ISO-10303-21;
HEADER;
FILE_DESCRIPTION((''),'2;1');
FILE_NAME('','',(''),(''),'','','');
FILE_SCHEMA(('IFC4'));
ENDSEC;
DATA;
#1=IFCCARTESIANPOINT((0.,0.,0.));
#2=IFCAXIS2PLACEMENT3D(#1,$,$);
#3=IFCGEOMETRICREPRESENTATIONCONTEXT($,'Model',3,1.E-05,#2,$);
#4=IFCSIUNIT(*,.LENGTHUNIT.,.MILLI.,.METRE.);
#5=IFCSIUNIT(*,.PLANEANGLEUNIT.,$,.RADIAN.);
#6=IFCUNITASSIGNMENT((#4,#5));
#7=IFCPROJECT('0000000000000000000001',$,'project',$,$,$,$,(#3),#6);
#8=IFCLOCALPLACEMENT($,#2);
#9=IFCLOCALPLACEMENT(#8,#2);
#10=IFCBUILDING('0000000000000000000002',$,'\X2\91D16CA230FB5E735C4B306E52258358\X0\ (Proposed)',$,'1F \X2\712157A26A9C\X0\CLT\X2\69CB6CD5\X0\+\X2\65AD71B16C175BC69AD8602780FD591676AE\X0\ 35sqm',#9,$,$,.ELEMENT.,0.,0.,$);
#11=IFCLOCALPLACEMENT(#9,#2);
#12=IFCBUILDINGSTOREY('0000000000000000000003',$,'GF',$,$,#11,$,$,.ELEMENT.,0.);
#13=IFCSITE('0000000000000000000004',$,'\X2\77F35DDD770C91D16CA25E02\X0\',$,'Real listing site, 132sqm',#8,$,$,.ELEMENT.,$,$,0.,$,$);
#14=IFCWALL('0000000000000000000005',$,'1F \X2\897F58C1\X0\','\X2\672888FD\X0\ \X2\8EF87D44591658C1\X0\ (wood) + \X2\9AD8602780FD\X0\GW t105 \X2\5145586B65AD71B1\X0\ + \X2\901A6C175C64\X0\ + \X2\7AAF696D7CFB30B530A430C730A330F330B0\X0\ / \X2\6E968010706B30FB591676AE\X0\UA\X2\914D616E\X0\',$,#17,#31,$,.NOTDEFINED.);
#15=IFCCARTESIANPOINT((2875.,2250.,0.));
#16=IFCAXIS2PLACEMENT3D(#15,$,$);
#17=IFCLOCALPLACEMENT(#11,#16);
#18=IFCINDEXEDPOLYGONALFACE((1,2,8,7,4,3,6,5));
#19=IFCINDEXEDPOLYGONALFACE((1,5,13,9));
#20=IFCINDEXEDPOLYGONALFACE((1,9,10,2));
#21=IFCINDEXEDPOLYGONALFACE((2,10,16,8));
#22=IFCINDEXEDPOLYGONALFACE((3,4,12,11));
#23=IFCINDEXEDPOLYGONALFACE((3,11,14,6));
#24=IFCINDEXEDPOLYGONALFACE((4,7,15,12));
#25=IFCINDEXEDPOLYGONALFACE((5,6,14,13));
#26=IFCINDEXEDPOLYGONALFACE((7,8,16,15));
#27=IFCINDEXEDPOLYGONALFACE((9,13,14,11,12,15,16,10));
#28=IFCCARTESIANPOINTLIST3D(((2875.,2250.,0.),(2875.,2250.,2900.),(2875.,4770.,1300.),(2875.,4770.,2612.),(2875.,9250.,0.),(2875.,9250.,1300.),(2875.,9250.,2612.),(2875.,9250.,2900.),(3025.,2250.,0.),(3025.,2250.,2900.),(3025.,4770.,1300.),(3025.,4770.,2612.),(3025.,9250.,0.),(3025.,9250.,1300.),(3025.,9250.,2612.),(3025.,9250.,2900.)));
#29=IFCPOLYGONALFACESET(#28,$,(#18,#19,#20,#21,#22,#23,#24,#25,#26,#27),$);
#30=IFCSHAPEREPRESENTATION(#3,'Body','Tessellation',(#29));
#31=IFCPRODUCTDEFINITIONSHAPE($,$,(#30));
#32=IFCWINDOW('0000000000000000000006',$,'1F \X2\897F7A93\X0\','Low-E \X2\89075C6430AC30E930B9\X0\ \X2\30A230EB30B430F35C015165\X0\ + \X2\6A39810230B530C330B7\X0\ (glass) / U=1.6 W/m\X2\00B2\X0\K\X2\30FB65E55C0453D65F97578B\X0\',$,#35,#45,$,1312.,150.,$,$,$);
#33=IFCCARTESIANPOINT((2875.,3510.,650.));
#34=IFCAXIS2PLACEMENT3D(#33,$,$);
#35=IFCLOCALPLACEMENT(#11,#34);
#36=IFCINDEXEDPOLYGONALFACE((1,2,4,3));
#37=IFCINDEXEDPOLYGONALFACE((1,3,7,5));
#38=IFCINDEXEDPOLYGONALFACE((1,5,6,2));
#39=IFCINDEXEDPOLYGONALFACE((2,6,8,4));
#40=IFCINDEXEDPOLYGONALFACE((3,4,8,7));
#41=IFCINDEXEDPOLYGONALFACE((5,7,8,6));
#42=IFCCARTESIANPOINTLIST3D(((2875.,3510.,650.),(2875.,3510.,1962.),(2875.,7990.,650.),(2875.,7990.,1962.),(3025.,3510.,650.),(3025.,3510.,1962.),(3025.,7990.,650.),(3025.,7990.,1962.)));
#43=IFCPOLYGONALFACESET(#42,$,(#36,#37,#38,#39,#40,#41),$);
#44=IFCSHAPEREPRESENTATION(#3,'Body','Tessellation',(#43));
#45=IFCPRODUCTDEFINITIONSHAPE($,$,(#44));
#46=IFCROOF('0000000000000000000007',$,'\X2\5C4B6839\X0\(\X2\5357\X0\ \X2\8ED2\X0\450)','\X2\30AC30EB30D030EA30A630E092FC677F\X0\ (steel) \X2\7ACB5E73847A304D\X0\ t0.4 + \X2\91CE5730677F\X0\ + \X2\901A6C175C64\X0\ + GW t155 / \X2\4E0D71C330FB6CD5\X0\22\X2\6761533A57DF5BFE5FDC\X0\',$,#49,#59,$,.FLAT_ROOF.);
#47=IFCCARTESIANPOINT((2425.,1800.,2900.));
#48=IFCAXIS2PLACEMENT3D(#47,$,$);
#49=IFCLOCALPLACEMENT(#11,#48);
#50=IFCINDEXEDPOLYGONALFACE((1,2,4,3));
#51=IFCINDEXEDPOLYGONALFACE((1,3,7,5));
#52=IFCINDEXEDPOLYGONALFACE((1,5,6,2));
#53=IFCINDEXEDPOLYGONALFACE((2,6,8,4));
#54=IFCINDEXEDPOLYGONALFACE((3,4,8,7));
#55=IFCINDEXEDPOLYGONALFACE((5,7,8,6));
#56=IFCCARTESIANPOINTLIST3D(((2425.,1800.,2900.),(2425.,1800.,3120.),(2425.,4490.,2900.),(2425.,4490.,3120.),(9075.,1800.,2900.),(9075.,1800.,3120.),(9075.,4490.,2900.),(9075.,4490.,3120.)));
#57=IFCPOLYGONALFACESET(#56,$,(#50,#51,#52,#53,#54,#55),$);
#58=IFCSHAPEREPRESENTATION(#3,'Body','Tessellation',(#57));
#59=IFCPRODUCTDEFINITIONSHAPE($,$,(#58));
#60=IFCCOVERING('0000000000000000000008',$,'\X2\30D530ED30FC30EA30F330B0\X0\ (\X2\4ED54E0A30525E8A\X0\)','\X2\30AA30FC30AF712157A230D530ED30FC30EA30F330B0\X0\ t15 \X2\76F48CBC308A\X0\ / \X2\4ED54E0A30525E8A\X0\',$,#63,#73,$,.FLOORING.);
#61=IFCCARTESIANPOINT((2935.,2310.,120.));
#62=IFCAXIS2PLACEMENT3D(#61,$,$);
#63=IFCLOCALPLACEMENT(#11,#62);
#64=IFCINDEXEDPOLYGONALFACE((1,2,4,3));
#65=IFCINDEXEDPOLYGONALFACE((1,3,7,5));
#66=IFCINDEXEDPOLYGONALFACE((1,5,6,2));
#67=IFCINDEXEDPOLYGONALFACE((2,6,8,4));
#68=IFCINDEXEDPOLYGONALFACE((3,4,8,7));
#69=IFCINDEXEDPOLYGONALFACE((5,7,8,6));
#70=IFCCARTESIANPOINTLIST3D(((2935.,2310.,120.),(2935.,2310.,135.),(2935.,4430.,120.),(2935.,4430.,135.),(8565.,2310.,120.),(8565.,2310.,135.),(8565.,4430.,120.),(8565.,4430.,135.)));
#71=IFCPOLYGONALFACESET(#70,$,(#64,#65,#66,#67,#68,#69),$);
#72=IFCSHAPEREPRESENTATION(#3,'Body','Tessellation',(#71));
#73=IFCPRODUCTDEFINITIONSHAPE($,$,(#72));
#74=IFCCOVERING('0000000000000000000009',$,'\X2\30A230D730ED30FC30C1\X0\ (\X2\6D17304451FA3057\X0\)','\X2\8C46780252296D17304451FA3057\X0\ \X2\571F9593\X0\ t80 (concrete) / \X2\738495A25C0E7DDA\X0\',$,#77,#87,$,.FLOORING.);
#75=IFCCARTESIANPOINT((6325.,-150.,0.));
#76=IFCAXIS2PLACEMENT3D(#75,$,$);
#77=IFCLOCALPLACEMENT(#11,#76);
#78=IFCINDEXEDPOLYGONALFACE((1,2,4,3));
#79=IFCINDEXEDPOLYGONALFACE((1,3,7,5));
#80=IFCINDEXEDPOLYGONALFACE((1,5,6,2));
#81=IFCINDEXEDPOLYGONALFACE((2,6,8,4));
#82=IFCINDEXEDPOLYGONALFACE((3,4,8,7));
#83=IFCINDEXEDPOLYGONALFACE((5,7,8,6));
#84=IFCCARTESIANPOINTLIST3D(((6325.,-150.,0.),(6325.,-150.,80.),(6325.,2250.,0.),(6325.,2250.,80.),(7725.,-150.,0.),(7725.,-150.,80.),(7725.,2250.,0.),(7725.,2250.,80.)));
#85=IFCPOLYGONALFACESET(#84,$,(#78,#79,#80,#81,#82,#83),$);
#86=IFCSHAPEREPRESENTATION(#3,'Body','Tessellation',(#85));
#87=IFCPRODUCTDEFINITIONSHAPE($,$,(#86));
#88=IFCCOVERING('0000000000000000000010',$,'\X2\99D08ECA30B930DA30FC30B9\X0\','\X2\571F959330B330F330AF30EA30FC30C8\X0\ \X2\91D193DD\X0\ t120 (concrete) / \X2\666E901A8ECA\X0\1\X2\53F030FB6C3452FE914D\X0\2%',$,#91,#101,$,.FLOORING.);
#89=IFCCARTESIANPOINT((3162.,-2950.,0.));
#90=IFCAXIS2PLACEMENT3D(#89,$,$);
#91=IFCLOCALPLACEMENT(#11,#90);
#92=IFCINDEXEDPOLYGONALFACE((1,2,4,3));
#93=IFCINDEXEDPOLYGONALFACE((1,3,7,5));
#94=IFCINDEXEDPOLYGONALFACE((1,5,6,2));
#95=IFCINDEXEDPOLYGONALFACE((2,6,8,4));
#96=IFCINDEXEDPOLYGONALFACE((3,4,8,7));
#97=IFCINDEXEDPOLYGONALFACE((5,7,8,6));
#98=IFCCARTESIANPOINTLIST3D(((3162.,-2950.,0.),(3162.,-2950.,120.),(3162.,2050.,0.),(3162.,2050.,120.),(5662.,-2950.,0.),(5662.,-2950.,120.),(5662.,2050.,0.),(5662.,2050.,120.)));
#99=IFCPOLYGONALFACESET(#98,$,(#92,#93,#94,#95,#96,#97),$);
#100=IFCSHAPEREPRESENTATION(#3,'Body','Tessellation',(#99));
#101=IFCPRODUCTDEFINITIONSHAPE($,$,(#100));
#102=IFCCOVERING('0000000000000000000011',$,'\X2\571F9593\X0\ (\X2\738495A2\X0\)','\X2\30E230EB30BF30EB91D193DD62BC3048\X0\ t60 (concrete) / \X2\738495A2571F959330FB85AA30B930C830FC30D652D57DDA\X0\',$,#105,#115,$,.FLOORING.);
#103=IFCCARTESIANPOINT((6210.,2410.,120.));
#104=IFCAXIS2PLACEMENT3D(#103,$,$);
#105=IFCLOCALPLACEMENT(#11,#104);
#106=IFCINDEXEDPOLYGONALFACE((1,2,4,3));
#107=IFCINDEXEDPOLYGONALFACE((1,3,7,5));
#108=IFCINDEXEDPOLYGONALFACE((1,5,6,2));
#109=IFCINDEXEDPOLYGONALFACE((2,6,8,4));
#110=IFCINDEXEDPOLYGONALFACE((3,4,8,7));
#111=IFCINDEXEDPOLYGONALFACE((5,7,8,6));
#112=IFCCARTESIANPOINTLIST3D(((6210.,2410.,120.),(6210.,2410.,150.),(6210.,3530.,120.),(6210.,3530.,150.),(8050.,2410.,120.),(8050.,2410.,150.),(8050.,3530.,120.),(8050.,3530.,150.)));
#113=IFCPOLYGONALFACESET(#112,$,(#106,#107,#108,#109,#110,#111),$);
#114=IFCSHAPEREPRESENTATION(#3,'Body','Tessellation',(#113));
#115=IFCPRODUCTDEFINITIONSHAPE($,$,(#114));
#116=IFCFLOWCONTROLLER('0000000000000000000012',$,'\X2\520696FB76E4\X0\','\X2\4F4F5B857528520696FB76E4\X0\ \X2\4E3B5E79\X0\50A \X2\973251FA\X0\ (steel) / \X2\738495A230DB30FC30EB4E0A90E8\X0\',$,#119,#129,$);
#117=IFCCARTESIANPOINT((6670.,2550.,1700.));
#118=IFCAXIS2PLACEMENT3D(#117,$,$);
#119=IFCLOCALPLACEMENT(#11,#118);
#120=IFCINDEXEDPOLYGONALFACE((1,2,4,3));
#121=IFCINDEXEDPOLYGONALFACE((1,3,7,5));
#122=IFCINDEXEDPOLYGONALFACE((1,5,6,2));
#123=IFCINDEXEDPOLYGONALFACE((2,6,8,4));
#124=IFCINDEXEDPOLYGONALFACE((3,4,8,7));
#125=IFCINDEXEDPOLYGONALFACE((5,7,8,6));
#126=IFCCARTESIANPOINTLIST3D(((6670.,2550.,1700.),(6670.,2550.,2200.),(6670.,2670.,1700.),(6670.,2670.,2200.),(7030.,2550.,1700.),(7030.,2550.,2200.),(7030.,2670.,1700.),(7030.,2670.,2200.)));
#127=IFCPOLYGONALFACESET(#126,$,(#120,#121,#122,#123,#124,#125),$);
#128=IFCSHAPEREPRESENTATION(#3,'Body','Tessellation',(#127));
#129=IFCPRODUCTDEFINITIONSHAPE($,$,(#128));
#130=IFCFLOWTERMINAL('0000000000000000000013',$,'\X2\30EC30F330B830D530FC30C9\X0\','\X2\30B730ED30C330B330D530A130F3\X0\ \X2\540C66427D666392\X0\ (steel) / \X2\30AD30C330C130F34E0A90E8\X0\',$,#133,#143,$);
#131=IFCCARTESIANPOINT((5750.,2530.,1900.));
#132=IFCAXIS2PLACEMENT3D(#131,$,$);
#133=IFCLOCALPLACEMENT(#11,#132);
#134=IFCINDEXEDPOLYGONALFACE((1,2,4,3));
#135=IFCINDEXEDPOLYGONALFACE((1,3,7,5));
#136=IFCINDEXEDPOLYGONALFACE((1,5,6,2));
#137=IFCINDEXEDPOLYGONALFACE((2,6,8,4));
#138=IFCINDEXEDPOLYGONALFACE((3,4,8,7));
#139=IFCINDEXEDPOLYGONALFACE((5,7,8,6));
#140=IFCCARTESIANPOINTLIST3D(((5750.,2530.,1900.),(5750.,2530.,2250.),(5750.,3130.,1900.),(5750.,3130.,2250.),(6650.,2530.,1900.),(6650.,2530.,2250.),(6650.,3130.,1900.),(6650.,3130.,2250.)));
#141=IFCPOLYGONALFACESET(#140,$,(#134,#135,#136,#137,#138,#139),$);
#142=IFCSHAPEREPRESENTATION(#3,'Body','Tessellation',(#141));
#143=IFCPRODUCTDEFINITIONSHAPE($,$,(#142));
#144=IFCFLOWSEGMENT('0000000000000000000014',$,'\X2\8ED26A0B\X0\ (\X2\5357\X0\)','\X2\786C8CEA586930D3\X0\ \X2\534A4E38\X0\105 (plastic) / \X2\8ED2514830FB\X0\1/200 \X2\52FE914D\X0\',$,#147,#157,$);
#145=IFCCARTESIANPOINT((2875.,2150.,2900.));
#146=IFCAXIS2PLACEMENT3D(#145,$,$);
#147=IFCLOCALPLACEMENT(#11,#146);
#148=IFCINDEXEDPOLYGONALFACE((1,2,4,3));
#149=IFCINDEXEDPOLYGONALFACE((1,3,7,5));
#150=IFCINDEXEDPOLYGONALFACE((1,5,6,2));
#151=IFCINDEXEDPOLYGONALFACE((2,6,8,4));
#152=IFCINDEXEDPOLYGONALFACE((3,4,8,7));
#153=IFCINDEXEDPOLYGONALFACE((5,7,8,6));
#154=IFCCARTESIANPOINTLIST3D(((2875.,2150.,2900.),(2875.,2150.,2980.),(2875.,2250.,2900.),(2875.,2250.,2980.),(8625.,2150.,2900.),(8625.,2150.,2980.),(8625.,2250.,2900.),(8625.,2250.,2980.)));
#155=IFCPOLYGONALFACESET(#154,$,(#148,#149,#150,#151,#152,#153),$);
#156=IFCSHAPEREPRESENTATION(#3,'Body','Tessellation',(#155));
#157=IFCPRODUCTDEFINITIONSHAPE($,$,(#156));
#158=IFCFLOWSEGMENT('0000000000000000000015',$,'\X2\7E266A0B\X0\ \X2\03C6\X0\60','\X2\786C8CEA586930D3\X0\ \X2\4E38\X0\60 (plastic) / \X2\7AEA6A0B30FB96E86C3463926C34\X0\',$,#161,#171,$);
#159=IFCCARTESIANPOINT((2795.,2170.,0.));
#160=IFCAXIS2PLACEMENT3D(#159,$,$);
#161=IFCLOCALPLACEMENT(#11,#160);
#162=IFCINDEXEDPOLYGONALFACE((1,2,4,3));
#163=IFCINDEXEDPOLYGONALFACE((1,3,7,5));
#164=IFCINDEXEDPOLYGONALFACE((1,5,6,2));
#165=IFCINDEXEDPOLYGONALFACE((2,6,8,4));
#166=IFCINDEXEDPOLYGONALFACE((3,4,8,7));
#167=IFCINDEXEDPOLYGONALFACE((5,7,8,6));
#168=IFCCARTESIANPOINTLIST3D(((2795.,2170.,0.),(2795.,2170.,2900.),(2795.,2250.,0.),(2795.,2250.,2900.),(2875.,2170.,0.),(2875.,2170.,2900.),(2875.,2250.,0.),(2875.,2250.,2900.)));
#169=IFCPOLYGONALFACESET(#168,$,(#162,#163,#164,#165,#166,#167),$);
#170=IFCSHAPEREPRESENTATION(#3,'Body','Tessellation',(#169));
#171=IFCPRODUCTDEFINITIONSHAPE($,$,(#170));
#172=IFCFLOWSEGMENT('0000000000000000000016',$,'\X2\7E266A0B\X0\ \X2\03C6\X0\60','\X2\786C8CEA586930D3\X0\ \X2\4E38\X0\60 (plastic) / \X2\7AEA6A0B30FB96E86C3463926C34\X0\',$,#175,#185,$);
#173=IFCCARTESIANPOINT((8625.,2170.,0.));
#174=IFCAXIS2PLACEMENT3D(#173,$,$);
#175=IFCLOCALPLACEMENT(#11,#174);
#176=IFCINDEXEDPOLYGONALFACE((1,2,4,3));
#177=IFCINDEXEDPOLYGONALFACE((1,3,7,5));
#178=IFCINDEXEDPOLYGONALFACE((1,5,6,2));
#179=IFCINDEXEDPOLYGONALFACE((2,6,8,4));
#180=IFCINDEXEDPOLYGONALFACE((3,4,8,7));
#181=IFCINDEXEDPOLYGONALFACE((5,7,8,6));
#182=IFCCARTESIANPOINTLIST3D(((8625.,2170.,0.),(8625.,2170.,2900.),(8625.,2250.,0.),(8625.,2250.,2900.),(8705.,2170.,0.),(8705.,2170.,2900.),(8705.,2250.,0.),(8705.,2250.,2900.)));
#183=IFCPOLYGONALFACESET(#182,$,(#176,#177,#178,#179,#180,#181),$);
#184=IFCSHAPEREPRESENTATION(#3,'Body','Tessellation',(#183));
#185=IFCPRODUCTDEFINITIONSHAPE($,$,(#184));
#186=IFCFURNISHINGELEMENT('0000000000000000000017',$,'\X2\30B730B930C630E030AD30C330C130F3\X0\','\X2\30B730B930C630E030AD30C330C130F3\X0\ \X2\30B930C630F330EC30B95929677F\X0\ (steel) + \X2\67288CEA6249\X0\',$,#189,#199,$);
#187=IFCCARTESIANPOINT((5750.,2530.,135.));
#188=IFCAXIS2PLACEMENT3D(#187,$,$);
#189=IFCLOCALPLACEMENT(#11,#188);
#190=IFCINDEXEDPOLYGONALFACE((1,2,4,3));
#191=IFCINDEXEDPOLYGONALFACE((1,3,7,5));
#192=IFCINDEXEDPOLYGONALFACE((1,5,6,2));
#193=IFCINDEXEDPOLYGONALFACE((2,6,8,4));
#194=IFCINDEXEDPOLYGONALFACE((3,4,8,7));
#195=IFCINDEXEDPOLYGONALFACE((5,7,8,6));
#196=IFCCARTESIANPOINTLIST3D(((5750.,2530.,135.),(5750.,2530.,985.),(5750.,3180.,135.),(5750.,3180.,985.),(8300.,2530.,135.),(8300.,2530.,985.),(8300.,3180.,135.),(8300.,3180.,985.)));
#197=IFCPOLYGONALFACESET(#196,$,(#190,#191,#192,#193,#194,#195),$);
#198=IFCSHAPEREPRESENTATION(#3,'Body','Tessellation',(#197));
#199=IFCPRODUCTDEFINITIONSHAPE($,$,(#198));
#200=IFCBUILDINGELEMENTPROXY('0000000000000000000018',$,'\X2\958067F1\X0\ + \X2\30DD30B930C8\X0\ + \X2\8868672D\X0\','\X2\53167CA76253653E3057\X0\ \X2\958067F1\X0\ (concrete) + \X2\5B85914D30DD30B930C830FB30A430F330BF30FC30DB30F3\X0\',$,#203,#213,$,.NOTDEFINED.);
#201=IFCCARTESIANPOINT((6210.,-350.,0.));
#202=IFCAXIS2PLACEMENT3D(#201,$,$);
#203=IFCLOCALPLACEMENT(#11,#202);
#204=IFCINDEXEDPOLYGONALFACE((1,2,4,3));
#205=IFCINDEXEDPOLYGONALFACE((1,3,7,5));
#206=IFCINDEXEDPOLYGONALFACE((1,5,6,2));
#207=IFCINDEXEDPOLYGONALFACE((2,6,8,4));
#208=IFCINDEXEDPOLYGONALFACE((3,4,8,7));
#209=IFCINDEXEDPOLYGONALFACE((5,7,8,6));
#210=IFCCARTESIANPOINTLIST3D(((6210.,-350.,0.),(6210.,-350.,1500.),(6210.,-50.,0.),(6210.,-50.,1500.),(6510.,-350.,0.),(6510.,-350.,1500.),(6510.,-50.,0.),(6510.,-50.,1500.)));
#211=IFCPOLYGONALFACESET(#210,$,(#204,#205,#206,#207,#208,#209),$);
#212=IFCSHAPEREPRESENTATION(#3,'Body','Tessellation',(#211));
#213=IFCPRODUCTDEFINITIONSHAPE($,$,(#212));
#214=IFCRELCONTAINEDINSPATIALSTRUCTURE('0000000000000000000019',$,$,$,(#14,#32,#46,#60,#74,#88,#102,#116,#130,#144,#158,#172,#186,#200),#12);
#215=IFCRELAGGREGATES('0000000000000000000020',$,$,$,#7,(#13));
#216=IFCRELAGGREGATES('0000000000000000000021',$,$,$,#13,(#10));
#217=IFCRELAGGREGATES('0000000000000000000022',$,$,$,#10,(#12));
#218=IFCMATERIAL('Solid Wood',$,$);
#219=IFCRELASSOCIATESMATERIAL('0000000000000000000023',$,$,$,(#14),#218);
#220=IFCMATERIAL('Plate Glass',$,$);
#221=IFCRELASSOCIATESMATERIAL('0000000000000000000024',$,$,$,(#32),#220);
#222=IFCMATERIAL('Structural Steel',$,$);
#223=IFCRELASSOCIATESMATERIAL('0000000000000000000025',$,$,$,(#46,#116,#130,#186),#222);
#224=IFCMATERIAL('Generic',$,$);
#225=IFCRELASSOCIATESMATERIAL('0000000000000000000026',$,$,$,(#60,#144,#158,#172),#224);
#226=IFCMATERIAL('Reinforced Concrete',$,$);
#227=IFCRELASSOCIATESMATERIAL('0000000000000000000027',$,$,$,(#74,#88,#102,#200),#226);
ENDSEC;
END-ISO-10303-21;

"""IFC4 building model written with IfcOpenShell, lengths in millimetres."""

from ifc_helpers import new_model, si_unit, frame, frame_2d, origin, place, context, project, spatial, rectangle, extrude, material, element, fill, save


model = new_model("IFC4")

# Units and contexts
model_context = context("Model", 3, precision=1e-05, world=origin())
ifc_project = project(units=[si_unit("LENGTHUNIT", "METRE", prefix="MILLI"), si_unit("PLANEANGLEUNIT", "RADIAN")], contexts=[model_context])

# Site, building, storey
site_placement = place(None, origin())
site = spatial("IfcSite", under=ifc_project, at=site_placement, Name="石川県金沢市", ObjectType="Real listing site, 132sqm", CompositionType="ELEMENT", RefElevation=0.0)
building_placement = place(site_placement, origin())
building = spatial("IfcBuilding", under=site, at=building_placement, Name="金沢・平屋の別荘 (Proposed)", ObjectType="1F 無垢檜CLT構法+断熱気密高性能外皮 35sqm", CompositionType="ELEMENT", ElevationOfRefHeight=0.0, ElevationOfTerrain=0.0)
storey_placement = place(building_placement, origin())
storey = spatial("IfcBuildingStorey", under=building, at=storey_placement, Name="GF", CompositionType="ELEMENT", Elevation=0.0)

# Shared definitions
ifc_material_1 = material(Name="Solid Wood")

# Shared definitions
ifc_material_2 = material(Name="Reinforced Concrete")

# Shared definitions
ifc_material_3 = material(Name="Plate Glass")

# Wall, opening, window
wall_1_placement = place(storey_placement, frame((2875.0, 2250.0, 0.0)))
wall_1 = element("IfcWall", 1, at=wall_1_placement, inside=storey, material=ifc_material_1, Name="1F 西壁", Description="木製 軸組外壁 (wood) + 高性能GW t105 充填断熱 + 通気層 + 窯業系サイディング / 準耐火・外皮UA配慮", PredefinedType="NOTDEFINED", context=model_context, shape_type="SweptSolid", body=[
    extrude(rectangle(XDim=150.0, YDim=7000.0, at=frame_2d((75.0, 3500.0))), frame((2875.0, 2250.0, 0.0)), (0.0, 0.0, 1.0), 2900.0),
])
opening_1_placement = place(storey_placement, frame((2875.0, 3510.0, 650.0)))
opening_1 = element("IfcOpeningElement", 2, at=opening_1_placement, cuts=wall_1, PredefinedType="NOTDEFINED", context=model_context, shape_type="SweptSolid", body=[
    extrude(rectangle(XDim=150.0, YDim=4480.0, at=frame_2d((75.0, 2240.0))), frame((2875.0, 3510.0, 650.0)), (0.0, 0.0, 1.0), 1312.0),
])
window_1_placement = place(storey_placement, frame((2875.0, 3510.0, 650.0)))
window_1 = element("IfcWindow", 3, at=window_1_placement, inside=storey, material=ifc_material_3, Name="1F 西窓", Description="Low-E 複層ガラス アルゴン封入 + 樹脂サッシ (glass) / U=1.6 W/m²K・日射取得型", OverallHeight=1312.0, OverallWidth=150.0, context=model_context, shape_type="SweptSolid", body=[
    extrude(rectangle(XDim=150.0, YDim=4480.0, at=frame_2d((75.0, 2240.0))), frame((2875.0, 3510.0, 650.0)), (0.0, 0.0, 1.0), 1312.0),
])
fill(opening_1, window_1)

# Roof
ifc_material_4 = material(Name="Structural Steel")
roof_placement = place(storey_placement, frame((2425.0, 1800.0, 2900.0)))
element("IfcRoof", 4, at=roof_placement, inside=storey, material=ifc_material_4, Name="屋根(南 軒450)", Description="ガルバリウム鋼板 (steel) 立平葺き t0.4 + 野地板 + 通気層 + GW t155 / 不燃・法22条区域対応", PredefinedType="FLAT_ROOF", context=model_context, shape_type="SweptSolid", body=[
    extrude(rectangle(XDim=6650.0, YDim=2690.0, at=frame_2d((3325.0, 1345.0))), frame((2425.0, 1800.0, 2900.0)), (0.0, 0.0, 1.0), 220.0),
])

# Coverings
ifc_material_5 = material(Name="Generic")
covering_1_placement = place(storey_placement, frame((2935.0, 2310.0, 120.0)))
element("IfcCovering", 5, at=covering_1_placement, inside=storey, material=ifc_material_5, Name="フローリング (仕上げ床)", Description="オーク無垢フローリング t15 直貼り / 仕上げ床", PredefinedType="FLOORING", context=model_context, shape_type="SweptSolid", body=[
    extrude(rectangle(XDim=5630.0, YDim=2120.0, at=frame_2d((2815.0, 1060.0))), frame((2935.0, 2310.0, 120.0)), (0.0, 0.0, 1.0), 15.0),
])
covering_2_placement = place(storey_placement, frame((6325.0, -150.0, 0.0)))
element("IfcCovering", 6, at=covering_2_placement, inside=storey, material=ifc_material_2, Name="アプローチ (洗い出し)", Description="豆砂利洗い出し 土間 t80 (concrete) / 玄関導線", PredefinedType="FLOORING", context=model_context, shape_type="SweptSolid", body=[
    extrude(rectangle(XDim=1400.0, YDim=2400.0, at=frame_2d((700.0, 1200.0))), frame((6325.0, -150.0, 0.0)), (0.0, 0.0, 1.0), 80.0),
])
covering_3_placement = place(storey_placement, frame((3162.0, -2950.0, 0.0)))
element("IfcCovering", 7, at=covering_3_placement, inside=storey, material=ifc_material_2, Name="駐車スペース", Description="土間コンクリート 金鏝 t120 (concrete) / 普通車1台・水勾配2%", PredefinedType="FLOORING", context=model_context, shape_type="SweptSolid", body=[
    extrude(rectangle(XDim=2500.0, YDim=5000.0, at=frame_2d((1250.0, 2500.0))), frame((3162.0, -2950.0, 0.0)), (0.0, 0.0, 1.0), 120.0),
])
covering_4_placement = place(storey_placement, frame((6210.0, 2410.0, 120.0)))
element("IfcCovering", 8, at=covering_4_placement, inside=storey, material=ifc_material_2, Name="土間 (玄関)", Description="モルタル金鏝押え t60 (concrete) / 玄関土間・薪ストーブ動線", PredefinedType="FLOORING", context=model_context, shape_type="SweptSolid", body=[
    extrude(rectangle(XDim=1840.0, YDim=1120.0, at=frame_2d((920.0, 560.0))), frame((6210.0, 2410.0, 120.0)), (0.0, 0.0, 1.0), 30.0),
])

# Flow controller
flow_controller_placement = place(storey_placement, frame((6670.0, 2550.0, 1700.0)))
element("IfcFlowController", 9, at=flow_controller_placement, inside=storey, material=ifc_material_4, Name="分電盤", Description="住宅用分電盤 主幹50A 露出 (steel) / 玄関ホール上部", context=model_context, shape_type="SweptSolid", body=[
    extrude(rectangle(XDim=360.0, YDim=120.0, at=frame_2d((180.0, 60.0))), frame((6670.0, 2550.0, 1700.0)), (0.0, 0.0, 1.0), 500.0),
])

# Flow terminal
flow_terminal_placement = place(storey_placement, frame((5750.0, 2530.0, 1900.0)))
element("IfcFlowTerminal", 10, at=flow_terminal_placement, inside=storey, material=ifc_material_4, Name="レンジフード", Description="シロッコファン 同時給排 (steel) / キッチン上部", context=model_context, shape_type="SweptSolid", body=[
    extrude(rectangle(XDim=900.0, YDim=600.0, at=frame_2d((450.0, 300.0))), frame((5750.0, 2530.0, 1900.0)), (0.0, 0.0, 1.0), 350.0),
])

# Flow segments
flow_segment_1_placement = place(storey_placement, frame((2875.0, 2150.0, 2900.0)))
element("IfcFlowSegment", 11, at=flow_segment_1_placement, inside=storey, material=ifc_material_5, Name="軒樋 (南)", Description="硬質塩ビ 半丸105 (plastic) / 軒先・1/200 勾配", context=model_context, shape_type="SweptSolid", body=[
    extrude(rectangle(XDim=5750.0, YDim=100.0, at=frame_2d((2875.0, 50.0))), frame((2875.0, 2150.0, 2900.0)), (0.0, 0.0, 1.0), 80.0),
])
flow_segment_2_placement = place(storey_placement, frame((2795.0, 2170.0, 0.0)))
element("IfcFlowSegment", 12, at=flow_segment_2_placement, inside=storey, material=ifc_material_5, Name="縦樋 φ60", Description="硬質塩ビ 丸60 (plastic) / 竪樋・雨水排水", context=model_context, shape_type="SweptSolid", body=[
    extrude(rectangle(XDim=80.0, YDim=80.0, at=frame_2d((40.0, 40.0))), frame((2795.0, 2170.0, 0.0)), (0.0, 0.0, 1.0), 2900.0),
])
flow_segment_3_placement = place(storey_placement, frame((8625.0, 2170.0, 0.0)))
element("IfcFlowSegment", 13, at=flow_segment_3_placement, inside=storey, material=ifc_material_5, Name="縦樋 φ60", Description="硬質塩ビ 丸60 (plastic) / 竪樋・雨水排水", context=model_context, shape_type="SweptSolid", body=[
    extrude(rectangle(XDim=80.0, YDim=80.0, at=frame_2d((40.0, 40.0))), frame((8625.0, 2170.0, 0.0)), (0.0, 0.0, 1.0), 2900.0),
])

# Furnishing element
furnishing_placement = place(storey_placement, frame((5750.0, 2530.0, 135.0)))
element("IfcFurnishingElement", 14, at=furnishing_placement, inside=storey, material=ifc_material_4, Name="システムキッチン", Description="システムキッチン ステンレス天板 (steel) + 木質扉", context=model_context, shape_type="SweptSolid", body=[
    extrude(rectangle(XDim=2550.0, YDim=650.0, at=frame_2d((1275.0, 325.0))), frame((5750.0, 2530.0, 135.0)), (0.0, 0.0, 1.0), 850.0),
])

# Building element proxy
proxy_placement = place(storey_placement, frame((6210.0, -350.0, 0.0)))
element("IfcBuildingElementProxy", 15, at=proxy_placement, inside=storey, material=ifc_material_2, Name="門柱 + ポスト + 表札", Description="化粧打放し 門柱 (concrete) + 宅配ポスト・インターホン", PredefinedType="NOTDEFINED", context=model_context, shape_type="SweptSolid", body=[
    extrude(rectangle(XDim=300.0, YDim=300.0, at=frame_2d((150.0, 150.0))), frame((6210.0, -350.0, 0.0)), (0.0, 0.0, 1.0), 1500.0),
])

save(model, "model.ifc")
